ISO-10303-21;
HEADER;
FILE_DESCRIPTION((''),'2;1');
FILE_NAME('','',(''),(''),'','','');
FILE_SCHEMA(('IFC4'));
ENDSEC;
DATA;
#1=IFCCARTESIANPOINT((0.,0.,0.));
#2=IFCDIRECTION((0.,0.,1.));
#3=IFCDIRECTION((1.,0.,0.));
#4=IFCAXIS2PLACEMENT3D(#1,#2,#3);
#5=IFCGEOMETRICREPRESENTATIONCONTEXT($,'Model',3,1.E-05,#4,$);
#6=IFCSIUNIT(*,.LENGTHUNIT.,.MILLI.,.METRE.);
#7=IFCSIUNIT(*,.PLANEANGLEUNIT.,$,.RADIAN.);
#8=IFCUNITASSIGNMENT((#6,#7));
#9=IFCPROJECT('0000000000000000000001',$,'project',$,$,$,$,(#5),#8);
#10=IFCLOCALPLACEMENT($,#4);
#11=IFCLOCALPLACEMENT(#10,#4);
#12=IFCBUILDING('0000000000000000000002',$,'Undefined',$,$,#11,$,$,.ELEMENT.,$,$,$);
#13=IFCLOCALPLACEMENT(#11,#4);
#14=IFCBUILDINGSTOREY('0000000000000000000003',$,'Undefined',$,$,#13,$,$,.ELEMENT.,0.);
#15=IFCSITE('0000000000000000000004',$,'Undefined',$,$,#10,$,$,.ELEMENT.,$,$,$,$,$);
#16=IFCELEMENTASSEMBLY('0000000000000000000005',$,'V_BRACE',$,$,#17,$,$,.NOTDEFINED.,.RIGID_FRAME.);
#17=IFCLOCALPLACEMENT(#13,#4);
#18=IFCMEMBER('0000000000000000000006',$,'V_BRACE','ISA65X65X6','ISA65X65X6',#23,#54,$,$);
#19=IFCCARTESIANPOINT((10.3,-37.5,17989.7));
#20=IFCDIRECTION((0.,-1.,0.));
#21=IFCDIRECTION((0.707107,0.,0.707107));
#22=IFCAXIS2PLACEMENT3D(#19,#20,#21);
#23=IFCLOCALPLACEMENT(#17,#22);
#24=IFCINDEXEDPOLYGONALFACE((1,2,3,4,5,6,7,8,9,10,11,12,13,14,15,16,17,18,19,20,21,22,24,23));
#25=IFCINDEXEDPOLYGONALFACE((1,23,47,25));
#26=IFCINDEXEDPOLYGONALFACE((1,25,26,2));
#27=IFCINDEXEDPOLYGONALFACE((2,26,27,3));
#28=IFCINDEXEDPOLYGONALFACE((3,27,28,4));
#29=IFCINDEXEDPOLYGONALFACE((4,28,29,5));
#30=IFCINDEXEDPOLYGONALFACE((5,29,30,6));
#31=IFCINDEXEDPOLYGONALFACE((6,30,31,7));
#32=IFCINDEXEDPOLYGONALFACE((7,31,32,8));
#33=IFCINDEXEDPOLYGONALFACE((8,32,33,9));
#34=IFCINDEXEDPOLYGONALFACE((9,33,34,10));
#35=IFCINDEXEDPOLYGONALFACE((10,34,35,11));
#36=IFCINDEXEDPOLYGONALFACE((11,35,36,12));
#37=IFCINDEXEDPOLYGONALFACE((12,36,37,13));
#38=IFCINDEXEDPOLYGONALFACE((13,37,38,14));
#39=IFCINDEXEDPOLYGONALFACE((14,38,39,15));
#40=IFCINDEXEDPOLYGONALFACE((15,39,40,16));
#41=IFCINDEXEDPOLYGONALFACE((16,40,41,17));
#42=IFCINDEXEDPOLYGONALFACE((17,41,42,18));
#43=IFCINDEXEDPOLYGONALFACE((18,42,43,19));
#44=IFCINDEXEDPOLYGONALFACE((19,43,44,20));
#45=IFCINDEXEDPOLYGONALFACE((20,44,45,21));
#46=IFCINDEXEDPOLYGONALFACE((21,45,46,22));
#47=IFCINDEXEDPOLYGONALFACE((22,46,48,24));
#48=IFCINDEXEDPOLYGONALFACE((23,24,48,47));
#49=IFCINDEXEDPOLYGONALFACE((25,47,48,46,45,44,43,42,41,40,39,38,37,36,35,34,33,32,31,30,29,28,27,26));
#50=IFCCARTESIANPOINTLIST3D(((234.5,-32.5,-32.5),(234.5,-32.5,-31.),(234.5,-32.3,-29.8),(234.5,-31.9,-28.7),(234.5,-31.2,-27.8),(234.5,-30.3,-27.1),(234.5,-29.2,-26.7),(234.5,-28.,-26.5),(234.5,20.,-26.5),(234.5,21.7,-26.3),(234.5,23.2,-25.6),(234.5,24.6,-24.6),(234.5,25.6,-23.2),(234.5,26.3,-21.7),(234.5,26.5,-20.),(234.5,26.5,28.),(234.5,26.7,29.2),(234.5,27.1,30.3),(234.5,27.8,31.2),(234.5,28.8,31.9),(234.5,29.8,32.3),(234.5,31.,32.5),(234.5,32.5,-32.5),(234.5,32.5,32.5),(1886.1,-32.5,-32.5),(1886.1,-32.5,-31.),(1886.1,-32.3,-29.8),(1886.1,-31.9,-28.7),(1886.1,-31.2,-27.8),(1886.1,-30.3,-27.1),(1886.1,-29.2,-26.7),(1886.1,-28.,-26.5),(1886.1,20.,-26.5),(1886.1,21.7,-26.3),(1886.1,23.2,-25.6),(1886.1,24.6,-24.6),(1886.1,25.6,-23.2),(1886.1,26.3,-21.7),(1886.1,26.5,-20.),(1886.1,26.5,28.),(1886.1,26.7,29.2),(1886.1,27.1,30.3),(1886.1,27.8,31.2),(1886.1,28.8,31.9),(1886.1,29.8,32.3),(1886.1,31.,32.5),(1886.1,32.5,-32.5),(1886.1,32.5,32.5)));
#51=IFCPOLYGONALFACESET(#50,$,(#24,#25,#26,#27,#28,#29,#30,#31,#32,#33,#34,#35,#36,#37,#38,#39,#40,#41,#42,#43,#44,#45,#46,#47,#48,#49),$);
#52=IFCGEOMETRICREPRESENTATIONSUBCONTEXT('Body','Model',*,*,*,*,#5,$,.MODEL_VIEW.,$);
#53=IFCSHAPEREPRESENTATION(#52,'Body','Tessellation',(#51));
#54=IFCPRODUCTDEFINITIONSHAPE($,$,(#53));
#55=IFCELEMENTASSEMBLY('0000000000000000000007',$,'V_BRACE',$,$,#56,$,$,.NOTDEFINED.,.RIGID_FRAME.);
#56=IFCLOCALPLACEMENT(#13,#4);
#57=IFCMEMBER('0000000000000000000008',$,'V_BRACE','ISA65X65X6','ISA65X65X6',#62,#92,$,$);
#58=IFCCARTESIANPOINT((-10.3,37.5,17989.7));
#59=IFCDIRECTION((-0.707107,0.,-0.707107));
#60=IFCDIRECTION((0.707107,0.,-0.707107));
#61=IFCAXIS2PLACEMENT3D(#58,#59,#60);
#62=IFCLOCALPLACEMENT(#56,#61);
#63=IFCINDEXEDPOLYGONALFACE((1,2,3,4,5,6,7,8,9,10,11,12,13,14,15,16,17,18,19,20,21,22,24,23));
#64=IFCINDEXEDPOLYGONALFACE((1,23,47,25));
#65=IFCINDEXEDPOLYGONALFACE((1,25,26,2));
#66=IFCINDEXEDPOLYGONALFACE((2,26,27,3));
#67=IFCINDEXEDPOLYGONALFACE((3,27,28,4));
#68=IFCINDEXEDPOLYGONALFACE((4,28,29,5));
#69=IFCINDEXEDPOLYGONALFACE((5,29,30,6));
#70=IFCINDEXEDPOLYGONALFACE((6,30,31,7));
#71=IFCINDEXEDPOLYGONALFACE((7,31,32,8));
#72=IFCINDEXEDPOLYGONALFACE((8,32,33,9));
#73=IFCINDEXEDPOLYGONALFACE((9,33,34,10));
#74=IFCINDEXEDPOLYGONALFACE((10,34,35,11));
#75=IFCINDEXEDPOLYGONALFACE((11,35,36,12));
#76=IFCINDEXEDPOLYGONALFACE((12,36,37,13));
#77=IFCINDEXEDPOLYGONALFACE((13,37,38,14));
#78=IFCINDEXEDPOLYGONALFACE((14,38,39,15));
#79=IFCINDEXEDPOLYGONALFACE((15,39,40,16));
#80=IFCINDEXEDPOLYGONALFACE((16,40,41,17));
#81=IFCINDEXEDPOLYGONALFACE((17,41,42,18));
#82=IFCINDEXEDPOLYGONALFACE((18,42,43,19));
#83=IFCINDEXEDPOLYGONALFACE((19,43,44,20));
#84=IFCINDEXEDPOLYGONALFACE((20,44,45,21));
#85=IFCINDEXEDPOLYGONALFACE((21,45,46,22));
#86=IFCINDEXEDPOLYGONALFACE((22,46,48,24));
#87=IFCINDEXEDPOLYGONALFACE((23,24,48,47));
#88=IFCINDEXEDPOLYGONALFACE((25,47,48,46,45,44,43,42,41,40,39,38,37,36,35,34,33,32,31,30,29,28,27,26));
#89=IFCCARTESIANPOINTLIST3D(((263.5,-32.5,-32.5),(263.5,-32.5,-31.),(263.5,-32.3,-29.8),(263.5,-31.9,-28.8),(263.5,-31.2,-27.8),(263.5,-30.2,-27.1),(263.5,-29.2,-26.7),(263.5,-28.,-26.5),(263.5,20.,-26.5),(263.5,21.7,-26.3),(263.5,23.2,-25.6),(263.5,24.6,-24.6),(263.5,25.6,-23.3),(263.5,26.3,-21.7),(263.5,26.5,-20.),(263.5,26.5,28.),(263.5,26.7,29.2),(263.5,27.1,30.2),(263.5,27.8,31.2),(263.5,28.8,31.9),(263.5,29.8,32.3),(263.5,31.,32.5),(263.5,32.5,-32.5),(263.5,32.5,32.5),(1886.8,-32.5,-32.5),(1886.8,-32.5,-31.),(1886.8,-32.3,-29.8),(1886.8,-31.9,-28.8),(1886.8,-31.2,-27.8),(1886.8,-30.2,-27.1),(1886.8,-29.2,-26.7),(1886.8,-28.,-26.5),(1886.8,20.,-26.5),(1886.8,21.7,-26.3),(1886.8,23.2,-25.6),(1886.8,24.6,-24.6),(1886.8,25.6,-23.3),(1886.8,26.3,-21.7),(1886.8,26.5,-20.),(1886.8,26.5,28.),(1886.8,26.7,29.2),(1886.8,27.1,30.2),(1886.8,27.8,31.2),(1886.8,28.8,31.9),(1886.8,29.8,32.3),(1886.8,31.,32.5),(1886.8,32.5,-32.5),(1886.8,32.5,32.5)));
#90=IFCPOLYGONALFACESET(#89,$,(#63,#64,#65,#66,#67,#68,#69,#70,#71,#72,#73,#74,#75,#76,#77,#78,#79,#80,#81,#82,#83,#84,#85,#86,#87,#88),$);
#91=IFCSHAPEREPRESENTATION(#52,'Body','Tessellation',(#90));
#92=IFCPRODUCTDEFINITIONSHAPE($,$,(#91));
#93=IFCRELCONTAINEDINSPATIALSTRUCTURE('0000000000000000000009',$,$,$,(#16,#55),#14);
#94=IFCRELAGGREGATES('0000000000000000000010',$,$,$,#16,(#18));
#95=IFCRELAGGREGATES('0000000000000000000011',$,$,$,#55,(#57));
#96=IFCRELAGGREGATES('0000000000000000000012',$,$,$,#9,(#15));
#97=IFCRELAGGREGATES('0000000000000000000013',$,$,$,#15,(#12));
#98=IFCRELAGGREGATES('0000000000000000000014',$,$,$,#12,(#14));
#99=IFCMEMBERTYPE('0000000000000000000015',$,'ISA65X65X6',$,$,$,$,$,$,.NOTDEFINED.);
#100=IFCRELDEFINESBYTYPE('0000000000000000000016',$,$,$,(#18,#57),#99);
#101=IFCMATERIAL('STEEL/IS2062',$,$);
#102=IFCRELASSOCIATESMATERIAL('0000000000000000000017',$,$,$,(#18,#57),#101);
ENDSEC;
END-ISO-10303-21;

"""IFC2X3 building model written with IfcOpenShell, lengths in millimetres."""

from ifc_helpers import new_model, si_unit, frame, origin_with_axes, origin_2d_with_axis, place, context, subcontext, project, spatial, l_section, extrude, clip, halfspace, material, type_object, element, aggregate, save


model = new_model("IFC2X3")

# Units and contexts
model_context = context("Model", 3, precision=1e-05, world=origin_with_axes())
body_context = subcontext(model_context, "Body", "Model", "MODEL_VIEW")
ifc_project = project(units=[si_unit("LENGTHUNIT", "METRE", prefix="MILLI"), si_unit("PLANEANGLEUNIT", "RADIAN")], contexts=[model_context])

# Site, building, storey
site_placement = place(None, origin_with_axes())
site = spatial("IfcSite", under=ifc_project, at=site_placement, Name="Undefined", CompositionType="ELEMENT")
building_placement = place(site_placement, origin_with_axes())
building = spatial("IfcBuilding", under=site, at=building_placement, Name="Undefined", CompositionType="ELEMENT")
storey_placement = place(building_placement, origin_with_axes())
storey = spatial("IfcBuildingStorey", under=building, at=storey_placement, Name="Undefined", CompositionType="ELEMENT", Elevation=0.0)

# Shared definitions
ifc_material_1 = material(Name="STEEL/IS2062")

# Element assemblies, members
assembly_1_placement = place(storey_placement, origin_with_axes())
assembly_1 = element("IfcElementAssembly", 1, at=assembly_1_placement, inside=storey, Name="V_BRACE", AssemblyPlace="NOTDEFINED", PredefinedType="RIGID_FRAME")
member_type_1 = type_object("IfcMemberType", Name="ISA65X65X6", PredefinedType="NOTDEFINED")
member_1_placement = place(assembly_1_placement, frame((10.3, -37.5, 17989.7), z_axis=(0.0, -1.0, 0.0), x_axis=(0.707107, 0.0, 0.707107)))
member_1 = element("IfcMember", 2, at=member_1_placement, type_object=member_type_1, material=ifc_material_1, Name="V_BRACE", Description="ISA65X65X6", ObjectType="ISA65X65X6", context=body_context, shape_type="Clipping", body=[
    clip(clip(extrude(l_section(Depth=65.0, Width=65.0, Thickness=6.0, FilletRadius=6.5, EdgeRadius=4.5, at=origin_2d_with_axis()), frame((2121.3, 0.0, 0.0), z_axis=(-1.0, 0.0, 0.0), x_axis=(0.0, -1.0, 0.0)), (0.0, 0.0, 1.0), 2121.3), halfspace(frame((1886.1, 0.0, -32.5), z_axis=(-1.0, 0.0, 0.0), x_axis=(0.0, -1.0, 0.0)), True)), halfspace(frame((234.5, 0.0, -32.5), z_axis=(1.0, 0.0, 0.0), x_axis=(0.0, 1.0, 0.0)), True)),
])
aggregate(assembly_1, [member_1])
assembly_2_placement = place(storey_placement, origin_with_axes())
assembly_2 = element("IfcElementAssembly", 3, at=assembly_2_placement, inside=storey, Name="V_BRACE", AssemblyPlace="NOTDEFINED", PredefinedType="RIGID_FRAME")
member_2_placement = place(assembly_2_placement, frame((-10.3, 37.5, 17989.7), z_axis=(-0.707107, 0.0, -0.707107), x_axis=(0.707107, 0.0, -0.707107)))
member_2 = element("IfcMember", 4, at=member_2_placement, type_object=member_type_1, material=ifc_material_1, Name="V_BRACE", Description="ISA65X65X6", ObjectType="ISA65X65X6", context=body_context, shape_type="Clipping", body=[
    clip(clip(extrude(l_section(Depth=65.0, Width=65.0, Thickness=6.0, FilletRadius=6.5, EdgeRadius=4.5, at=origin_2d_with_axis()), frame((2121.3, 0.0, 0.0), z_axis=(-1.0, 0.0, 0.0), x_axis=(0.0, -1.0, 0.0)), (0.0, 0.0, 1.0), 2121.3), halfspace(frame((1886.8, 42.5, 0.0), z_axis=(-1.0, 0.0, 0.0), x_axis=(0.0, 0.0, 1.0)), True)), halfspace(frame((263.5, 42.5, 0.0), z_axis=(1.0, 0.0, 0.0), x_axis=(0.0, 0.0, -1.0)), True)),
])
aggregate(assembly_2, [member_2])

save(model, "model.ifc")
